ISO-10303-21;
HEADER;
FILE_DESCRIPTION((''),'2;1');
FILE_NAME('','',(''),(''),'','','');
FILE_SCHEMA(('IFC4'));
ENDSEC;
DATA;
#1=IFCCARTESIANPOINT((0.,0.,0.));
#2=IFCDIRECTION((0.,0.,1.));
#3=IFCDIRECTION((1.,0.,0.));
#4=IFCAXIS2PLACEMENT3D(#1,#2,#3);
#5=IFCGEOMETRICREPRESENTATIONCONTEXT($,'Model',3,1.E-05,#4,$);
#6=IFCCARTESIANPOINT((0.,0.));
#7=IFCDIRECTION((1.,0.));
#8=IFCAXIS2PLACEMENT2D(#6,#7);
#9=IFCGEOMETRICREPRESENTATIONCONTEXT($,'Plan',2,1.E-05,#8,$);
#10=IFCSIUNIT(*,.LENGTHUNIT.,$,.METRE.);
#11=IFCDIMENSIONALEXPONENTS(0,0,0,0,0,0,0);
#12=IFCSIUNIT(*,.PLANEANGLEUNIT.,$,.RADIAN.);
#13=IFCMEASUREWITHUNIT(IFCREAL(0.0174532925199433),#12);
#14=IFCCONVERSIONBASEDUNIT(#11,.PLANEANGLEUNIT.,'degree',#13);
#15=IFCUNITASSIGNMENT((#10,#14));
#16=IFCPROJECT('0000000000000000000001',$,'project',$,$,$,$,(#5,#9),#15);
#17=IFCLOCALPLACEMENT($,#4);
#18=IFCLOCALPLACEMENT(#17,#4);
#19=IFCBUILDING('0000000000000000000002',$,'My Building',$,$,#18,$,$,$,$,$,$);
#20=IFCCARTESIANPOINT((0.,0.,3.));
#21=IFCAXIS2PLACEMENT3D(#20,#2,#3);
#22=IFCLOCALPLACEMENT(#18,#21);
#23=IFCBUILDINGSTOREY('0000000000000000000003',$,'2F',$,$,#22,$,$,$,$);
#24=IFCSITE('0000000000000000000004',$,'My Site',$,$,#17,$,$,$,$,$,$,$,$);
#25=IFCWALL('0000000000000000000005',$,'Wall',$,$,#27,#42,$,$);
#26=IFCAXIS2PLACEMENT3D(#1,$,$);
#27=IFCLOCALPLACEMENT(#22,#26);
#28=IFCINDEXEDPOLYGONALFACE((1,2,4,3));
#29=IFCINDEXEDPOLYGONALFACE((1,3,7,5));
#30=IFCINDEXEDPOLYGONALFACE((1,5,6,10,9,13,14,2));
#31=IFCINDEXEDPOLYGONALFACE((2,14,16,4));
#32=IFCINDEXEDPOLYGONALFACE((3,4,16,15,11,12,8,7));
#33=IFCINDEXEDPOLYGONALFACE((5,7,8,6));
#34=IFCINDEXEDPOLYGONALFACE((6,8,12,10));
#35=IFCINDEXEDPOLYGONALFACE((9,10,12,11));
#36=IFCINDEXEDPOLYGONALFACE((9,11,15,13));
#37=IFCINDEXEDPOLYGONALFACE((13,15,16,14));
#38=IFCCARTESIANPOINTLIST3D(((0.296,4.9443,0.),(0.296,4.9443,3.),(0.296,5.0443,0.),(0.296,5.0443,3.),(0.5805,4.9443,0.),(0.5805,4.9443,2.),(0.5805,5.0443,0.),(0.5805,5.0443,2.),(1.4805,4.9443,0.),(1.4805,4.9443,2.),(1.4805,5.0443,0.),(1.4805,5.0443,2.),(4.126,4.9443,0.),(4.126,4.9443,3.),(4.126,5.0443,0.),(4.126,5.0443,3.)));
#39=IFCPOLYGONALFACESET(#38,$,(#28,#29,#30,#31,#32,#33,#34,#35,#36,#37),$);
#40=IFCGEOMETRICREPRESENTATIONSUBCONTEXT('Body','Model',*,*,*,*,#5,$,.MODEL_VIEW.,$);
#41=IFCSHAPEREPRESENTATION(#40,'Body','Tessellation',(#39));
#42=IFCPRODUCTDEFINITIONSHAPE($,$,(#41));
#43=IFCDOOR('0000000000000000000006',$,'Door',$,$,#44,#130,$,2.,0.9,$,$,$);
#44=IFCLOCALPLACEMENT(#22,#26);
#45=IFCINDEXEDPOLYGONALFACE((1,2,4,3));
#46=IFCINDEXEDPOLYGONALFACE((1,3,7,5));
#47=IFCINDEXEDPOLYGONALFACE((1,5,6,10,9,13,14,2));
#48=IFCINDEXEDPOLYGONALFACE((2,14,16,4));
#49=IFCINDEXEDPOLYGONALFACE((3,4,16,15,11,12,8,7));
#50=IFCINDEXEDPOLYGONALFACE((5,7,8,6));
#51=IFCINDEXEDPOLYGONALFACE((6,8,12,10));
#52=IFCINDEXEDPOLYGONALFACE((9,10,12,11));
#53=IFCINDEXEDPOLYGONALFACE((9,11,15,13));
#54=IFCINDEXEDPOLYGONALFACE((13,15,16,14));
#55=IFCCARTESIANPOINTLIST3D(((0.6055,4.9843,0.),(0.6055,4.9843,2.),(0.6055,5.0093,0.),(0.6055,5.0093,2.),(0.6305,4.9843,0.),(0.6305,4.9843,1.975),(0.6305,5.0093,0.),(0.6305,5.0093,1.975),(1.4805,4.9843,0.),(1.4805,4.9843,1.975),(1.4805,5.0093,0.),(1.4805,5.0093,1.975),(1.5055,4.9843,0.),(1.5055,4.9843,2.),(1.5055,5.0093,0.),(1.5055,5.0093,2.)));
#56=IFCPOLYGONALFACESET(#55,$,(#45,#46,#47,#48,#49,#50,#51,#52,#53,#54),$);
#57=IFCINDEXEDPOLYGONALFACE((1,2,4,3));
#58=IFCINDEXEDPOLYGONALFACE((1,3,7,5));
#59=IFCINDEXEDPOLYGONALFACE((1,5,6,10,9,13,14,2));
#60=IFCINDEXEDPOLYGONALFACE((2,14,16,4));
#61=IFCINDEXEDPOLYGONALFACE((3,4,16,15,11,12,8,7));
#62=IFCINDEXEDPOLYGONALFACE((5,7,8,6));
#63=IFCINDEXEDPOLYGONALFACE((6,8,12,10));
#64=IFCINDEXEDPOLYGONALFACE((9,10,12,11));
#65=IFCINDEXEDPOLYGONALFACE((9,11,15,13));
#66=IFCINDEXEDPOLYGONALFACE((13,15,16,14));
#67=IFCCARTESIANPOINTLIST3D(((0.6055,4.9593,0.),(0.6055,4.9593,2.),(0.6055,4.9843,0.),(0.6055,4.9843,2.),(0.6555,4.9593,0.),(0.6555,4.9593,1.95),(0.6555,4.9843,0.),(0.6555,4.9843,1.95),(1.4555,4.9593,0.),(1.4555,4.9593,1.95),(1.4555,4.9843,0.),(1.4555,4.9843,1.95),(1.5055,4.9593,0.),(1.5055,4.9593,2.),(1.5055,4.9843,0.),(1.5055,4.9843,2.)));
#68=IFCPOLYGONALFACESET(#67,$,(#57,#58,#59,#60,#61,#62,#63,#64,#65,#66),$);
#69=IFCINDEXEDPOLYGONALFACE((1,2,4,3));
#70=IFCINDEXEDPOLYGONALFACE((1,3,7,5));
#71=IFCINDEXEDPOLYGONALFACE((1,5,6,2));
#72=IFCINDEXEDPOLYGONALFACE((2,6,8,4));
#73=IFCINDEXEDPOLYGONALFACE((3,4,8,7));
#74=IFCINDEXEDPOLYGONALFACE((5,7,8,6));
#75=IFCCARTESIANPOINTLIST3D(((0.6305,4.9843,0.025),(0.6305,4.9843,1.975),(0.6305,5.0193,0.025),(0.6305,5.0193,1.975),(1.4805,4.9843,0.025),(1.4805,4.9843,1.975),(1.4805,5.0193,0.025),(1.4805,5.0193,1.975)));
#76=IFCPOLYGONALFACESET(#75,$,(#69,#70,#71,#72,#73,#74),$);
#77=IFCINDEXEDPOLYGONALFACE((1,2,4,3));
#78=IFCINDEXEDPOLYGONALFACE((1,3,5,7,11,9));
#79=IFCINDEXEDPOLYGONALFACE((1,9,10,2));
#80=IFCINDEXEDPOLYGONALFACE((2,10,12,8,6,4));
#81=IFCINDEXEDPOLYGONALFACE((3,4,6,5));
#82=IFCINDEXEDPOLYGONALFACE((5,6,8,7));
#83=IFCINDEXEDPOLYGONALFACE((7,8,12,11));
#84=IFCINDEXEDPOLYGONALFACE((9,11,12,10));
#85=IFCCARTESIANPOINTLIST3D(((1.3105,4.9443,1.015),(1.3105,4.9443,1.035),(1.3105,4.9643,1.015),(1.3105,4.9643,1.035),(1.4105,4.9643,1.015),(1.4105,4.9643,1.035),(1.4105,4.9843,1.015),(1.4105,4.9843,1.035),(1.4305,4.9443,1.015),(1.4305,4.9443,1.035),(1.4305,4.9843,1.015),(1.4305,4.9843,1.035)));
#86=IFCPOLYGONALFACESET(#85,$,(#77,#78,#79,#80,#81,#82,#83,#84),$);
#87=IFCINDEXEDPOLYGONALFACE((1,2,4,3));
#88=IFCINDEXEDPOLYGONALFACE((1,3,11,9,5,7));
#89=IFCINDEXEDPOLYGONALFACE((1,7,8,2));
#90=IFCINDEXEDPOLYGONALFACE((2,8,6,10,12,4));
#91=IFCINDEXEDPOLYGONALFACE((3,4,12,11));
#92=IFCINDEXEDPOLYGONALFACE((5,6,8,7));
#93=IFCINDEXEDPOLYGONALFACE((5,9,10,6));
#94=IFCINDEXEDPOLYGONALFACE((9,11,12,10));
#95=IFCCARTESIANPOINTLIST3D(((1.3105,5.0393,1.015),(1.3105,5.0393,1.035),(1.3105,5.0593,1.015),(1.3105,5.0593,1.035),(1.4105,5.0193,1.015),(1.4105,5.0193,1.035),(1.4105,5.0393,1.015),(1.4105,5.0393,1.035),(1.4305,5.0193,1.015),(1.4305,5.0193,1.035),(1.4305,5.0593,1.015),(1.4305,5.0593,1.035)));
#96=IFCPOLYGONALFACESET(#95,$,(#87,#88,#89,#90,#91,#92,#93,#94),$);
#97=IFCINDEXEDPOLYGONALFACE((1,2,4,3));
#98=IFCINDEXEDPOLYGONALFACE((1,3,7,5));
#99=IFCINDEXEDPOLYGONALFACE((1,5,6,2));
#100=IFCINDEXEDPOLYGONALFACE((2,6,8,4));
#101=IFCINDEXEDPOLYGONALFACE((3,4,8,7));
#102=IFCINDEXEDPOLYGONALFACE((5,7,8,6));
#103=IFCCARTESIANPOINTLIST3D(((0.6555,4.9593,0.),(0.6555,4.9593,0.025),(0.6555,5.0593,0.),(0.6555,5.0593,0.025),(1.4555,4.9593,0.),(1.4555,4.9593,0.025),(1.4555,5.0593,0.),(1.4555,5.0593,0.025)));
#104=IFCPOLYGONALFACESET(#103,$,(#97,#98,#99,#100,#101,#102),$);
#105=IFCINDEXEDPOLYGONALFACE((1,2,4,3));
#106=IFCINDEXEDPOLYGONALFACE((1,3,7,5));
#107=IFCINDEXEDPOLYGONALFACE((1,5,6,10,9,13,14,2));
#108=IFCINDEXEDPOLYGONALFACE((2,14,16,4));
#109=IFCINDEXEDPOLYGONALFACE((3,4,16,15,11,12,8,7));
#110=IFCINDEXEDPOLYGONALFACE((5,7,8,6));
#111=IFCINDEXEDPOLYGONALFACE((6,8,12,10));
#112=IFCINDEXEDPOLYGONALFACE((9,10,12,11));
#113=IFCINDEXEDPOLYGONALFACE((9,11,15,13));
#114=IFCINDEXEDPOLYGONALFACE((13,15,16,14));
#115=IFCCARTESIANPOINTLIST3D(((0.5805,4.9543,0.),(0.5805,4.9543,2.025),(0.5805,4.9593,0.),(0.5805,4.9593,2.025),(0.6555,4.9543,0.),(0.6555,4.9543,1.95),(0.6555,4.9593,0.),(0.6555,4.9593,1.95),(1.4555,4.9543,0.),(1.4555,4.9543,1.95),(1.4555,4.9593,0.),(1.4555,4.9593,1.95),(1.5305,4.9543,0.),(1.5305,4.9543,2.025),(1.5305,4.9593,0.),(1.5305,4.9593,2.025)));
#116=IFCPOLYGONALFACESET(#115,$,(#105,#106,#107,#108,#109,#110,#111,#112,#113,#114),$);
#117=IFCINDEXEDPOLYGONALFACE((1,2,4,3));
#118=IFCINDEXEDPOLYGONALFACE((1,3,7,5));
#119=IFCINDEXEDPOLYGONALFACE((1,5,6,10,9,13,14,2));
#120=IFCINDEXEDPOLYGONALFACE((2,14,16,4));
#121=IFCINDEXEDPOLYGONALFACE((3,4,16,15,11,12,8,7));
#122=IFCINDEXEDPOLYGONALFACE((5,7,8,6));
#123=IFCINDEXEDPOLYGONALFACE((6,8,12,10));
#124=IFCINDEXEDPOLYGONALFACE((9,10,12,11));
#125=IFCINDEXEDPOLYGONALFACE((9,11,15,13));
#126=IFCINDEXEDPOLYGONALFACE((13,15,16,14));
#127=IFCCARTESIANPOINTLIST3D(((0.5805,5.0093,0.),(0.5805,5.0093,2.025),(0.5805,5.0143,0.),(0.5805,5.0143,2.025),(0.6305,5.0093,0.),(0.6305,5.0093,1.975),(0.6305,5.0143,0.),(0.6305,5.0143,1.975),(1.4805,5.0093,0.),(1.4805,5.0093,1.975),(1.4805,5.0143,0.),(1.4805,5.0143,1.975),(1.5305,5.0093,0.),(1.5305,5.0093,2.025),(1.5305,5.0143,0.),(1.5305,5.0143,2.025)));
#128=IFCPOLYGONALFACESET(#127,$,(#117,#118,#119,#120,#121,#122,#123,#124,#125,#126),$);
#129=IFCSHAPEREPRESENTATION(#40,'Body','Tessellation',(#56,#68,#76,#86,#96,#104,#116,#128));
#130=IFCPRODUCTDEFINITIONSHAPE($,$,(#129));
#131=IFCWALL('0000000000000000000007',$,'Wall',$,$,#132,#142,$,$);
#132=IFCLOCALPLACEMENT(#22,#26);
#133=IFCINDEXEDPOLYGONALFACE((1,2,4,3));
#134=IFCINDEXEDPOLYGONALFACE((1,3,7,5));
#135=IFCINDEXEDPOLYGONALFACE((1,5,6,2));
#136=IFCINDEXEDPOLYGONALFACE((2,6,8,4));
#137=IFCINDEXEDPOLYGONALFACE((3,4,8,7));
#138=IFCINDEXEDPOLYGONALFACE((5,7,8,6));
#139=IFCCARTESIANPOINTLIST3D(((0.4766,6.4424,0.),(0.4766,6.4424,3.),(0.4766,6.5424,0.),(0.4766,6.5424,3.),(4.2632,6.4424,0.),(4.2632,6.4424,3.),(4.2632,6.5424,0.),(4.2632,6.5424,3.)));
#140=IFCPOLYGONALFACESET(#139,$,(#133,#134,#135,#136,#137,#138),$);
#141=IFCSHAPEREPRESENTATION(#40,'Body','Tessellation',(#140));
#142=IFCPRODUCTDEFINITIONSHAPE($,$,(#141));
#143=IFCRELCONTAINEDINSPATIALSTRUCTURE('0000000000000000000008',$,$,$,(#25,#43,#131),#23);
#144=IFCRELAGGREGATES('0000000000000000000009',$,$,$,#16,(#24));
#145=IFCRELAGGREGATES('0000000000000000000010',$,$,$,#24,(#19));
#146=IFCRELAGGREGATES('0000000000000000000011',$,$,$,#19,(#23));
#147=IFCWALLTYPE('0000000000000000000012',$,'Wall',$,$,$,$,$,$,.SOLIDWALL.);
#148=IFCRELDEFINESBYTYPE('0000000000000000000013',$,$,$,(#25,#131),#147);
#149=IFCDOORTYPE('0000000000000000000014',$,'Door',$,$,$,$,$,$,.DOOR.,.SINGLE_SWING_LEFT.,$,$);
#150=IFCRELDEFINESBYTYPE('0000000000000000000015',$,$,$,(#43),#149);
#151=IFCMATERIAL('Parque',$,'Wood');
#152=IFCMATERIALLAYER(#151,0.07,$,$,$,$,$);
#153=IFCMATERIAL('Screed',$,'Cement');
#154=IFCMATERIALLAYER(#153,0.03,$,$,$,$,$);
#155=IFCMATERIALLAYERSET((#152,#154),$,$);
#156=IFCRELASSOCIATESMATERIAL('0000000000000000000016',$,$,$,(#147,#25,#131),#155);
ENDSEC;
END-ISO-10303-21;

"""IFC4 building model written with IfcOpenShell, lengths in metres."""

from ifc_helpers import new_model, entity, si_unit, converted_unit, frame, origin_with_axes, origin_2d_with_axis, place, context, subcontext, project, spatial, line, indexed_curve, outline, extrude, shape, source, transform, mapped, material, layer, layer_set, layer_usage, type_object, type_shapes, element, fill, save


model = new_model("IFC4")

# Units and contexts
model_context = context("Model", 3, precision=1e-05, world=origin_with_axes())
plan_context = context("Plan", 2, precision=1e-05, world=origin_2d_with_axis())
body_context_1 = subcontext(model_context, "Body", "Model", "MODEL_VIEW")
body_context_2 = subcontext(plan_context, "Body", "Plan", "PLAN_VIEW")
ifc_project = project(units=[si_unit("LENGTHUNIT", "METRE"), converted_unit("PLANEANGLEUNIT", "degree", entity("IfcReal", 0.0174532925199433), si_unit("PLANEANGLEUNIT", "RADIAN"), dimensions=[0, 0, 0, 0, 0, 0, 0])], contexts=[model_context, plan_context])

# Site, building, storey
site_placement = place(None, origin_with_axes())
site = spatial("IfcSite", under=ifc_project, at=site_placement, Name="My Site")
building_placement = place(site_placement, origin_with_axes())
building = spatial("IfcBuilding", under=site, at=building_placement, Name="My Building")
storey_placement = place(building_placement, frame((0.0, 0.0, 3.0), z_axis=(0.0, 0.0, 1.0), x_axis=(1.0, 0.0, 0.0)))
storey = spatial("IfcBuildingStorey", under=building, at=storey_placement, Name="2F")

# Shared definitions
ifc_material_1 = material(Name="Parque", Category="Wood")
ifc_layer_1 = layer(ifc_material_1, 0.07)
ifc_material_2 = material(Name="Screed", Category="Cement")
ifc_layer_2 = layer(ifc_material_2, 0.03)
ifc_layer_set = layer_set([ifc_layer_1, ifc_layer_2])
wall_type = type_object("IfcWallType", Name="Wall", PredefinedType="SOLIDWALL", material=ifc_layer_set)

# Wall, opening, door
shared_shape_1 = source(origin_with_axes(), body_context_1, "Body", "SweptSolid", [
    extrude(outline(indexed_curve([(0.0, 0.0), (0.9, 0.0), (0.9, 2.0), (0.0, 2.0)], segments=[line(1, 2, 3, 4, 1)])), frame((0.0, -0.6, 0.0), z_axis=(0.0, -1.0, 0.0), x_axis=(1.0, 0.0, 0.0)), (0.0, 0.0, -1.0), 1.2),
])
door_type_1 = type_object("IfcDoorType", Name="Door", OperationType="SINGLE_SWING_LEFT", PredefinedType="DOOR")
shared_shape_2 = source(origin_with_axes(), body_context_1, "Body", "SweptSolid", [
    extrude(outline(indexed_curve([(0.0, 0.0), (0.0, 2.0), (0.9, 2.0), (0.9, 0.0), (0.875, 0.0), (0.875, 1.975), (0.025, 1.975), (0.025, 0.0)], segments=[line(1, 2, 3, 4, 5, 6, 7, 8, 1)])), frame((0.0, 0.025, 0.0), z_axis=(0.0, -1.0, 0.0), x_axis=(1.0, 0.0, 0.0)), (0.0, 0.0, -1.0), 0.025),
    extrude(outline(indexed_curve([(0.0, 0.0), (0.0, 2.0), (0.9, 2.0), (0.9, 0.0), (0.85, 0.0), (0.85, 1.95), (0.05, 1.95), (0.05, 0.0)], segments=[line(1, 2, 3, 4, 5, 6, 7, 8, 1)])), frame((0.0, 0.0, 0.0), z_axis=(0.0, -1.0, 0.0), x_axis=(1.0, 0.0, 0.0)), (0.0, 0.0, -1.0), 0.025),
    extrude(outline(indexed_curve([(0.0, 0.0), (0.85, 0.0), (0.85, 0.035), (0.0, 0.035)], segments=[line(1, 2, 3, 4, 1)])), frame((0.025, 0.025, 0.025), z_axis=(0.0, 0.0, 1.0), x_axis=(1.0, 0.0, 0.0)), (0.0, 0.0, 1.0), 1.95),
    extrude(outline(indexed_curve([(0.0, 0.0), (0.0, -0.04), (-0.12, -0.04), (-0.12, -0.02), (-0.02, -0.02), (-0.02, 0.0)], segments=[line(1, 2, 3, 4, 5, 6, 1)])), frame((0.825, 0.025, 1.015), z_axis=(0.0, 0.0, 1.0), x_axis=(1.0, 0.0, 0.0)), (0.0, 0.0, 1.0), 0.02),
    extrude(outline(indexed_curve([(0.0, 0.0), (0.0, 0.04), (-0.12, 0.04), (-0.12, 0.02), (-0.02, 0.02), (-0.02, 0.0)], segments=[line(1, 2, 3, 4, 5, 6, 1)])), frame((0.825, 0.06, 1.015), z_axis=(0.0, 0.0, 1.0), x_axis=(1.0, 0.0, 0.0)), (0.0, 0.0, 1.0), 0.02),
    extrude(outline(indexed_curve([(0.0, 0.0), (0.8, 0.0), (0.8, 0.1), (0.0, 0.1)], segments=[line(1, 2, 3, 4, 1)])), frame((0.05, 0.0, 0.0), z_axis=(0.0, 0.0, 1.0), x_axis=(1.0, 0.0, 0.0)), (0.0, 0.0, 1.0), 0.025),
    extrude(outline(indexed_curve([(0.0, 0.0), (0.0, 2.025), (0.95, 2.025), (0.95, 0.0), (0.875, 0.0), (0.875, 1.95), (0.075, 1.95), (0.075, 0.0)], segments=[line(1, 2, 3, 4, 5, 6, 7, 8, 1)])), frame((-0.025, -0.005, 0.0), z_axis=(0.0, -1.0, 0.0), x_axis=(1.0, 0.0, 0.0)), (0.0, 0.0, -1.0), 0.005),
    extrude(outline(indexed_curve([(0.0, 0.0), (0.0, 2.025), (0.95, 2.025), (0.95, 0.0), (0.9, 0.0), (0.9, 1.975), (0.05, 1.975), (0.05, 0.0)], segments=[line(1, 2, 3, 4, 5, 6, 7, 8, 1)])), frame((-0.025, 0.05, 0.0), z_axis=(0.0, -1.0, 0.0), x_axis=(1.0, 0.0, 0.0)), (0.0, 0.0, -1.0), 0.005),
])
shared_shape_3 = source(origin_with_axes(), body_context_2, "Body", "Curve2D", [
    entity("IfcIndexedPolyCurve", entity("IfcCartesianPointList2D", [[0.0, 0.0], [0.0, 0.05], [0.025, 0.05], [0.025, 0.025], [0.05, 0.025], [0.05, 0.0]]), [entity("IfcLineIndex", [1, 2, 3, 4, 5, 6, 1])]),
    entity("IfcIndexedPolyCurve", entity("IfcCartesianPointList2D", [[0.9, 0.0], [0.9, 0.05], [0.875, 0.05], [0.875, 0.025], [0.85, 0.025], [0.85, 0.0]]), [entity("IfcLineIndex", [1, 2, 3, 4, 5, 6, 1])]),
    entity("IfcTrimmedCurve", entity("IfcEllipse", entity("IfcAxis2Placement2D", entity("IfcCartesianPoint", [0.06, 0.05]), entity("IfcDirection", [1.0, 0.0])), 0.815, 0.85), [entity("IfcCartesianPoint", [0.875, 0.05])], [entity("IfcCartesianPoint", [0.06, 0.9])], True, "CARTESIAN"),
    entity("IfcIndexedPolyCurve", entity("IfcCartesianPointList2D", [[0.025, 0.05], [0.06, 0.05], [0.06, 0.9], [0.025, 0.9]]), [entity("IfcLineIndex", [1, 2, 3, 4, 1])]),
])
type_shapes(door_type_1, [shared_shape_2, shared_shape_3])
ifc_layer_usage_1 = layer_usage(ifc_layer_set, "AXIS2", "POSITIVE", 0.0)
wall_1_placement = place(storey_placement, frame((4.126, 5.0443, 0.0), z_axis=(0.0, 0.0, 1.0), x_axis=(-1.0, -0.000001, 0.0)))
wall_1 = element("IfcWall", 1, at=wall_1_placement, inside=storey, type_object=wall_type, material=ifc_layer_usage_1, Name="Wall", context=body_context_1, shape_type="SweptSolid", body=[
    extrude(outline(indexed_curve([(0.0, 0.0), (0.0, 0.1), (3.83, 0.1), (3.83, 0.0)], segments=[line(1, 2, 3, 4, 1)])), origin_with_axes(), (0.0, 0.0, 1.0), 3.0),
])
opening_1_placement = place(wall_1_placement, frame((2.6455, 0.0, 0.0), z_axis=(0.0, 0.0, 1.0), x_axis=(1.0, 0.0, 0.0)))
opening_1 = element("IfcOpeningElement", 2, at=opening_1_placement, cuts=wall_1, PredefinedType="OPENING", context=body_context_1, shape_type="MappedRepresentation", body=[
    mapped(shared_shape_1, transform((0.0, 0.0, 0.0), x_axis=(1.0, 0.0, 0.0), y_axis=(0.0, 1.0, 0.0), z_axis=(0.0, 0.0, 1.0), scale=1.0)),
])
door_1_placement = place(opening_1_placement, frame((0.875, 0.085, 0.0), z_axis=(0.0, 0.0, 1.0), x_axis=(-1.0, 0.0, 0.0)))
door_1 = element("IfcDoor", 3, at=door_1_placement, inside=storey, type_object=door_type_1, Name="Door", OverallHeight=2.0, OverallWidth=0.9, shapes=[
    shape(body_context_1, "Body", "MappedRepresentation", [mapped(shared_shape_2, transform((0.0, 0.0, 0.0), x_axis=(1.0, 0.0, 0.0), y_axis=(0.0, 1.0, 0.0), z_axis=(0.0, 0.0, 1.0), scale=1.0))]),
    shape(body_context_2, "Body", "MappedRepresentation", [mapped(shared_shape_3, transform((0.0, 0.0, 0.0), x_axis=(1.0, 0.0, 0.0), y_axis=(0.0, 1.0, 0.0), z_axis=(0.0, 0.0, 1.0), scale=1.0))]),
])
fill(opening_1, door_1)

# Wall
ifc_layer_usage_2 = layer_usage(ifc_layer_set, "AXIS2", "POSITIVE", 0.0)
wall_2_placement = place(storey_placement, frame((4.2632, 6.5424, 0.0), z_axis=(0.0, 0.0, 1.0), x_axis=(-1.0, 0.0, 0.0)))
element("IfcWall", 4, at=wall_2_placement, inside=storey, type_object=wall_type, material=ifc_layer_usage_2, Name="Wall", context=body_context_1, shape_type="SweptSolid", body=[
    extrude(outline(indexed_curve([(0.0, 0.0), (0.0, 0.1), (3.7865, 0.1), (3.7865, 0.0)], segments=[line(1, 2, 3, 4, 1)])), origin_with_axes(), (0.0, 0.0, 1.0), 3.0),
])

save(model, "model.ifc")
